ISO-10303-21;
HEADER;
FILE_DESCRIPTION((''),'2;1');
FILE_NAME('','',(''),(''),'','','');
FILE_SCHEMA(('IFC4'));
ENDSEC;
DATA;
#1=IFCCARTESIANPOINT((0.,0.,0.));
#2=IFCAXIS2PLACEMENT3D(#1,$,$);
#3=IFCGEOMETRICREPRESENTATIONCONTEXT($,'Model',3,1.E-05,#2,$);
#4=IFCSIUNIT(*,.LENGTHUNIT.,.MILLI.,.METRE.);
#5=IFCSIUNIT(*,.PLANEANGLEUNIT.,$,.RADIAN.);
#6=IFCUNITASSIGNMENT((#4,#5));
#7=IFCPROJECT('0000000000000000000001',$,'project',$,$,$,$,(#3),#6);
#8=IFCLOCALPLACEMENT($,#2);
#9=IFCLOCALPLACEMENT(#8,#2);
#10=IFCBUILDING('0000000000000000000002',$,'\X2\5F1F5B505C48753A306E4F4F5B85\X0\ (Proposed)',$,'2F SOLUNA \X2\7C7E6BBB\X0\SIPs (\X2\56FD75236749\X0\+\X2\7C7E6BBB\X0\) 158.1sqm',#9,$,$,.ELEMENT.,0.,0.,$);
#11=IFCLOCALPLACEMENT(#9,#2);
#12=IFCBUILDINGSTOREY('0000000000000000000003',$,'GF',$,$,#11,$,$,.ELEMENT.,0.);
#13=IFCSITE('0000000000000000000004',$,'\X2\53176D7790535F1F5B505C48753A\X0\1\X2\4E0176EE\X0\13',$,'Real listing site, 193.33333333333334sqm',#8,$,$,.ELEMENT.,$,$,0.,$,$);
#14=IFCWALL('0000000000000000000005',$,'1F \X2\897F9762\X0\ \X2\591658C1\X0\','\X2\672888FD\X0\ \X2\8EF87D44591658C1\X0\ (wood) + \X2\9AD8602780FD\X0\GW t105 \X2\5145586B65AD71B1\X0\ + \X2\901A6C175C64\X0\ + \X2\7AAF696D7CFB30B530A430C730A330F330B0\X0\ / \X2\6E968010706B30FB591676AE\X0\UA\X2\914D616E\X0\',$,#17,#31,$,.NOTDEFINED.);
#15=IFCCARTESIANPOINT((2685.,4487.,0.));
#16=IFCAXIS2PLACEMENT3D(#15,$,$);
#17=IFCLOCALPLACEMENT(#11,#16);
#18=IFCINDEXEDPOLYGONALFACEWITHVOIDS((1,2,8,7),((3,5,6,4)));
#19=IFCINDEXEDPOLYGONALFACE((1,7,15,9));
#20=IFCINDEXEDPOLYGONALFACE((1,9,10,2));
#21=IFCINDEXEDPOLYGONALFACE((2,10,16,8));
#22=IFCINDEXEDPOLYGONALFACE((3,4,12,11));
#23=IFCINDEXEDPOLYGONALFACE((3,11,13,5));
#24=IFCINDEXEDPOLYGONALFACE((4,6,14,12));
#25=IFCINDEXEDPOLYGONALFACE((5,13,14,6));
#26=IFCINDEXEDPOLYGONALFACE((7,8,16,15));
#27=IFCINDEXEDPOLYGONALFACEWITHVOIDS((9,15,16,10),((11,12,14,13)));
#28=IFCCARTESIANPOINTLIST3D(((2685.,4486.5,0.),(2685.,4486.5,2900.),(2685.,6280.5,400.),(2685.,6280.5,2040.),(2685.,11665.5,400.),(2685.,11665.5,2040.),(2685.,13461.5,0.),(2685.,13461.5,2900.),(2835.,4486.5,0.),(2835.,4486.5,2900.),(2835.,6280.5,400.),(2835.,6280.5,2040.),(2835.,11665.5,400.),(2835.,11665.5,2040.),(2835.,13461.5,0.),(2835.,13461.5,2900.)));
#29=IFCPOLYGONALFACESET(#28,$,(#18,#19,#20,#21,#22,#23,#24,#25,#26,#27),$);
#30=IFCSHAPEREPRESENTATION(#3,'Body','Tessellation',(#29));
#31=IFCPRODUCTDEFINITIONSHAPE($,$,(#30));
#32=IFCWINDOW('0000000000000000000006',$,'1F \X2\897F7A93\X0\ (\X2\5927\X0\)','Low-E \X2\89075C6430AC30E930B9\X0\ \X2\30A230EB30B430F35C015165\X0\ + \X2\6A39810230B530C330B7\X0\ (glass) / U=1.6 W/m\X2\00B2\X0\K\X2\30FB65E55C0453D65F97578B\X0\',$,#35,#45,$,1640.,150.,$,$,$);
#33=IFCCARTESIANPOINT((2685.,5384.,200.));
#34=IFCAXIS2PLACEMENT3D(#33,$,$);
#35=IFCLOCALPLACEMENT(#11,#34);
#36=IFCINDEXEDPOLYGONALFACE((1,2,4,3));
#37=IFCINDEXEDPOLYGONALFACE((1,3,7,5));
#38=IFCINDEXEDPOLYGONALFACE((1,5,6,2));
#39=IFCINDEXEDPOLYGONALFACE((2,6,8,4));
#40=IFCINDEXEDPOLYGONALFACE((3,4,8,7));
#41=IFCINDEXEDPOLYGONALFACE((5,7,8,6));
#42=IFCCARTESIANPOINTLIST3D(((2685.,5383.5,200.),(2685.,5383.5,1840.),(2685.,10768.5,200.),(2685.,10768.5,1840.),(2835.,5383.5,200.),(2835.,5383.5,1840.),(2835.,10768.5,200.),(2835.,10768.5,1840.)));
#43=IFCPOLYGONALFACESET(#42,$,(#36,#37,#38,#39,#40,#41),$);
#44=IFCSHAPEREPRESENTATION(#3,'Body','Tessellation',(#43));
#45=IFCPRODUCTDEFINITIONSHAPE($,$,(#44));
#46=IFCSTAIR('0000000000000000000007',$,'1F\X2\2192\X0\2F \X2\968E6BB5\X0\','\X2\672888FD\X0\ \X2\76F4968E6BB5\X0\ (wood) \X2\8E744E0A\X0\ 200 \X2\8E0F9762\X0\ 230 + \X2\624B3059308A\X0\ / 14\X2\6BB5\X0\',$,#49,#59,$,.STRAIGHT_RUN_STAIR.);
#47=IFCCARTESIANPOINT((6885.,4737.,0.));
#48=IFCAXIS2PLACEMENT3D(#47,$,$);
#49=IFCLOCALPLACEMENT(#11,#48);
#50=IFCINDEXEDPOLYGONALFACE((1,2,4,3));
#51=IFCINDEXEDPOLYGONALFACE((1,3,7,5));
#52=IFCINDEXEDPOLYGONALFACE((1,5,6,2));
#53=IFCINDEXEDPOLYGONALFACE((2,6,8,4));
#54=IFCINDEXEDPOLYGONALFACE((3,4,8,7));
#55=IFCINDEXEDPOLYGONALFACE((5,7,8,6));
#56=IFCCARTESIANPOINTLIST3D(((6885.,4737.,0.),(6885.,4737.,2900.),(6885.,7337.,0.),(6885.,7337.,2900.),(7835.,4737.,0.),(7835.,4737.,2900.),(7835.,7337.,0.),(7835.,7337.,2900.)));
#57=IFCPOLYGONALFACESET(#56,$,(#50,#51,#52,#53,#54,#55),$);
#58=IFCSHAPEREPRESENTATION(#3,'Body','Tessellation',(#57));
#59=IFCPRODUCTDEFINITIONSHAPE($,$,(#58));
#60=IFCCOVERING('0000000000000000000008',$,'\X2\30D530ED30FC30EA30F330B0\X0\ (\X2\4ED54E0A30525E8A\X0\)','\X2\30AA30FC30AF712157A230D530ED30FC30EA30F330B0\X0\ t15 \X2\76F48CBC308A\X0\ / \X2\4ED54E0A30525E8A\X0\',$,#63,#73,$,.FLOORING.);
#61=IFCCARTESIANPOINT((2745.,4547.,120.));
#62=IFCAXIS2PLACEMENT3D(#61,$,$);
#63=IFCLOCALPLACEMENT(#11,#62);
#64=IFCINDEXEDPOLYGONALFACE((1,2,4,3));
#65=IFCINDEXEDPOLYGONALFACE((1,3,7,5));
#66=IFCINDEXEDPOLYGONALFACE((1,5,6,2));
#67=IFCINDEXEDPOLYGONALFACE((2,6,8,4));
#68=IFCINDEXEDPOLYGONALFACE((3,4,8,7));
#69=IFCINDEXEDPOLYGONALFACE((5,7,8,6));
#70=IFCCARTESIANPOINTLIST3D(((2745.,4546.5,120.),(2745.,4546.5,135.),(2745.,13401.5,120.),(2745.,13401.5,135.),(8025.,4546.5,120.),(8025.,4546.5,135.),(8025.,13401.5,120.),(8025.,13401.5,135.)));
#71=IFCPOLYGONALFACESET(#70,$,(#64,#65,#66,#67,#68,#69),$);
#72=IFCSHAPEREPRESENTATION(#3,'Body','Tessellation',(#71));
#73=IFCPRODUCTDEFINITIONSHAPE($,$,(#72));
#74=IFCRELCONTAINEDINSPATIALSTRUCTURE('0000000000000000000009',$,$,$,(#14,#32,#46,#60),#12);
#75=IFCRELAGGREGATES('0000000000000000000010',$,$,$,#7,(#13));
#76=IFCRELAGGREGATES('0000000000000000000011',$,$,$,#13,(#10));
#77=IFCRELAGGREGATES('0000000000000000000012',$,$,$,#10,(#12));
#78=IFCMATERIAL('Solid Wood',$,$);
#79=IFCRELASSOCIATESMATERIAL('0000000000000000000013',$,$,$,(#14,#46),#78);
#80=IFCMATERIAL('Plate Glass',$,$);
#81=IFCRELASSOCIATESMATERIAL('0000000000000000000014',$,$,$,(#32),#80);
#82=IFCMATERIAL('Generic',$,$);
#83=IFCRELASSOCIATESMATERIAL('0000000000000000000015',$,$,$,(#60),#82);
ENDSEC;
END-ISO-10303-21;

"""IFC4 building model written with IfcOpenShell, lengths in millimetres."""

from ifc_helpers import new_model, si_unit, frame, frame_2d, origin, place, context, project, spatial, rectangle, extrude, material, element, fill, save


model = new_model("IFC4")

# Units and contexts
model_context = context("Model", 3, precision=1e-05, world=origin())
ifc_project = project(units=[si_unit("LENGTHUNIT", "METRE", prefix="MILLI"), si_unit("PLANEANGLEUNIT", "RADIAN")], contexts=[model_context])

# Site, building, storey
site_placement = place(None, origin())
site = spatial("IfcSite", under=ifc_project, at=site_placement, Name="北海道弟子屈町1丁目13", ObjectType="Real listing site, 193.33333333333334sqm", CompositionType="ELEMENT", RefElevation=0.0)
building_placement = place(site_placement, origin())
building = spatial("IfcBuilding", under=site, at=building_placement, Name="弟子屈町の住宅 (Proposed)", ObjectType="2F SOLUNA 籾殻SIPs (国産杉+籾殻) 158.1sqm", CompositionType="ELEMENT", ElevationOfRefHeight=0.0, ElevationOfTerrain=0.0)
storey_placement = place(building_placement, origin())
storey = spatial("IfcBuildingStorey", under=building, at=storey_placement, Name="GF", CompositionType="ELEMENT", Elevation=0.0)

# Shared definitions
ifc_material_1 = material(Name="Solid Wood")
ifc_material_2 = material(Name="Generic")

# Shared definitions
ifc_material_3 = material(Name="Plate Glass")

# Wall, opening, window
wall_1_placement = place(storey_placement, frame((2685.0, 4487.0, 0.0)))
wall_1 = element("IfcWall", 1, at=wall_1_placement, inside=storey, material=ifc_material_1, Name="1F 西面 外壁", Description="木製 軸組外壁 (wood) + 高性能GW t105 充填断熱 + 通気層 + 窯業系サイディング / 準耐火・外皮UA配慮", PredefinedType="NOTDEFINED", context=model_context, shape_type="SweptSolid", body=[
    extrude(rectangle(XDim=150.0, YDim=8975.0, at=frame_2d((75.0, 4487.0))), frame((2685.0, 4487.0, 0.0)), (0.0, 0.0, 1.0), 2900.0),
])
opening_1_placement = place(storey_placement, frame((2685.0, 5384.0, 200.0)))
opening_1 = element("IfcOpeningElement", 2, at=opening_1_placement, cuts=wall_1, PredefinedType="NOTDEFINED", context=model_context, shape_type="SweptSolid", body=[
    extrude(rectangle(XDim=150.0, YDim=5385.0, at=frame_2d((75.0, 2692.0))), frame((2685.0, 5384.0, 200.0)), (0.0, 0.0, 1.0), 1640.0),
])
window_1_placement = place(storey_placement, frame((2685.0, 5384.0, 200.0)))
window_1 = element("IfcWindow", 3, at=window_1_placement, inside=storey, material=ifc_material_3, Name="1F 西窓 (大)", Description="Low-E 複層ガラス アルゴン封入 + 樹脂サッシ (glass) / U=1.6 W/m²K・日射取得型", OverallHeight=1640.0, OverallWidth=150.0, context=model_context, shape_type="SweptSolid", body=[
    extrude(rectangle(XDim=150.0, YDim=5385.0, at=frame_2d((75.0, 2692.0))), frame((2685.0, 5384.0, 200.0)), (0.0, 0.0, 1.0), 1640.0),
])
fill(opening_1, window_1)

# Stair
stair_placement = place(storey_placement, frame((6885.0, 4737.0, 0.0)))
element("IfcStair", 4, at=stair_placement, inside=storey, material=ifc_material_1, Name="1F→2F 階段", Description="木製 直階段 (wood) 蹴上 200 踏面 230 + 手すり / 14段", PredefinedType="STRAIGHT_RUN_STAIR", context=model_context, shape_type="SweptSolid", body=[
    extrude(rectangle(XDim=950.0, YDim=2600.0, at=frame_2d((475.0, 1300.0))), frame((6885.0, 4737.0, 0.0)), (0.0, 0.0, 1.0), 2900.0),
])

# Covering
covering_placement = place(storey_placement, frame((2745.0, 4547.0, 120.0)))
element("IfcCovering", 5, at=covering_placement, inside=storey, material=ifc_material_2, Name="フローリング (仕上げ床)", Description="オーク無垢フローリング t15 直貼り / 仕上げ床", PredefinedType="FLOORING", context=model_context, shape_type="SweptSolid", body=[
    extrude(rectangle(XDim=5280.0, YDim=8855.0, at=frame_2d((2640.0, 4427.0))), frame((2745.0, 4547.0, 120.0)), (0.0, 0.0, 1.0), 15.0),
])

save(model, "model.ifc")
